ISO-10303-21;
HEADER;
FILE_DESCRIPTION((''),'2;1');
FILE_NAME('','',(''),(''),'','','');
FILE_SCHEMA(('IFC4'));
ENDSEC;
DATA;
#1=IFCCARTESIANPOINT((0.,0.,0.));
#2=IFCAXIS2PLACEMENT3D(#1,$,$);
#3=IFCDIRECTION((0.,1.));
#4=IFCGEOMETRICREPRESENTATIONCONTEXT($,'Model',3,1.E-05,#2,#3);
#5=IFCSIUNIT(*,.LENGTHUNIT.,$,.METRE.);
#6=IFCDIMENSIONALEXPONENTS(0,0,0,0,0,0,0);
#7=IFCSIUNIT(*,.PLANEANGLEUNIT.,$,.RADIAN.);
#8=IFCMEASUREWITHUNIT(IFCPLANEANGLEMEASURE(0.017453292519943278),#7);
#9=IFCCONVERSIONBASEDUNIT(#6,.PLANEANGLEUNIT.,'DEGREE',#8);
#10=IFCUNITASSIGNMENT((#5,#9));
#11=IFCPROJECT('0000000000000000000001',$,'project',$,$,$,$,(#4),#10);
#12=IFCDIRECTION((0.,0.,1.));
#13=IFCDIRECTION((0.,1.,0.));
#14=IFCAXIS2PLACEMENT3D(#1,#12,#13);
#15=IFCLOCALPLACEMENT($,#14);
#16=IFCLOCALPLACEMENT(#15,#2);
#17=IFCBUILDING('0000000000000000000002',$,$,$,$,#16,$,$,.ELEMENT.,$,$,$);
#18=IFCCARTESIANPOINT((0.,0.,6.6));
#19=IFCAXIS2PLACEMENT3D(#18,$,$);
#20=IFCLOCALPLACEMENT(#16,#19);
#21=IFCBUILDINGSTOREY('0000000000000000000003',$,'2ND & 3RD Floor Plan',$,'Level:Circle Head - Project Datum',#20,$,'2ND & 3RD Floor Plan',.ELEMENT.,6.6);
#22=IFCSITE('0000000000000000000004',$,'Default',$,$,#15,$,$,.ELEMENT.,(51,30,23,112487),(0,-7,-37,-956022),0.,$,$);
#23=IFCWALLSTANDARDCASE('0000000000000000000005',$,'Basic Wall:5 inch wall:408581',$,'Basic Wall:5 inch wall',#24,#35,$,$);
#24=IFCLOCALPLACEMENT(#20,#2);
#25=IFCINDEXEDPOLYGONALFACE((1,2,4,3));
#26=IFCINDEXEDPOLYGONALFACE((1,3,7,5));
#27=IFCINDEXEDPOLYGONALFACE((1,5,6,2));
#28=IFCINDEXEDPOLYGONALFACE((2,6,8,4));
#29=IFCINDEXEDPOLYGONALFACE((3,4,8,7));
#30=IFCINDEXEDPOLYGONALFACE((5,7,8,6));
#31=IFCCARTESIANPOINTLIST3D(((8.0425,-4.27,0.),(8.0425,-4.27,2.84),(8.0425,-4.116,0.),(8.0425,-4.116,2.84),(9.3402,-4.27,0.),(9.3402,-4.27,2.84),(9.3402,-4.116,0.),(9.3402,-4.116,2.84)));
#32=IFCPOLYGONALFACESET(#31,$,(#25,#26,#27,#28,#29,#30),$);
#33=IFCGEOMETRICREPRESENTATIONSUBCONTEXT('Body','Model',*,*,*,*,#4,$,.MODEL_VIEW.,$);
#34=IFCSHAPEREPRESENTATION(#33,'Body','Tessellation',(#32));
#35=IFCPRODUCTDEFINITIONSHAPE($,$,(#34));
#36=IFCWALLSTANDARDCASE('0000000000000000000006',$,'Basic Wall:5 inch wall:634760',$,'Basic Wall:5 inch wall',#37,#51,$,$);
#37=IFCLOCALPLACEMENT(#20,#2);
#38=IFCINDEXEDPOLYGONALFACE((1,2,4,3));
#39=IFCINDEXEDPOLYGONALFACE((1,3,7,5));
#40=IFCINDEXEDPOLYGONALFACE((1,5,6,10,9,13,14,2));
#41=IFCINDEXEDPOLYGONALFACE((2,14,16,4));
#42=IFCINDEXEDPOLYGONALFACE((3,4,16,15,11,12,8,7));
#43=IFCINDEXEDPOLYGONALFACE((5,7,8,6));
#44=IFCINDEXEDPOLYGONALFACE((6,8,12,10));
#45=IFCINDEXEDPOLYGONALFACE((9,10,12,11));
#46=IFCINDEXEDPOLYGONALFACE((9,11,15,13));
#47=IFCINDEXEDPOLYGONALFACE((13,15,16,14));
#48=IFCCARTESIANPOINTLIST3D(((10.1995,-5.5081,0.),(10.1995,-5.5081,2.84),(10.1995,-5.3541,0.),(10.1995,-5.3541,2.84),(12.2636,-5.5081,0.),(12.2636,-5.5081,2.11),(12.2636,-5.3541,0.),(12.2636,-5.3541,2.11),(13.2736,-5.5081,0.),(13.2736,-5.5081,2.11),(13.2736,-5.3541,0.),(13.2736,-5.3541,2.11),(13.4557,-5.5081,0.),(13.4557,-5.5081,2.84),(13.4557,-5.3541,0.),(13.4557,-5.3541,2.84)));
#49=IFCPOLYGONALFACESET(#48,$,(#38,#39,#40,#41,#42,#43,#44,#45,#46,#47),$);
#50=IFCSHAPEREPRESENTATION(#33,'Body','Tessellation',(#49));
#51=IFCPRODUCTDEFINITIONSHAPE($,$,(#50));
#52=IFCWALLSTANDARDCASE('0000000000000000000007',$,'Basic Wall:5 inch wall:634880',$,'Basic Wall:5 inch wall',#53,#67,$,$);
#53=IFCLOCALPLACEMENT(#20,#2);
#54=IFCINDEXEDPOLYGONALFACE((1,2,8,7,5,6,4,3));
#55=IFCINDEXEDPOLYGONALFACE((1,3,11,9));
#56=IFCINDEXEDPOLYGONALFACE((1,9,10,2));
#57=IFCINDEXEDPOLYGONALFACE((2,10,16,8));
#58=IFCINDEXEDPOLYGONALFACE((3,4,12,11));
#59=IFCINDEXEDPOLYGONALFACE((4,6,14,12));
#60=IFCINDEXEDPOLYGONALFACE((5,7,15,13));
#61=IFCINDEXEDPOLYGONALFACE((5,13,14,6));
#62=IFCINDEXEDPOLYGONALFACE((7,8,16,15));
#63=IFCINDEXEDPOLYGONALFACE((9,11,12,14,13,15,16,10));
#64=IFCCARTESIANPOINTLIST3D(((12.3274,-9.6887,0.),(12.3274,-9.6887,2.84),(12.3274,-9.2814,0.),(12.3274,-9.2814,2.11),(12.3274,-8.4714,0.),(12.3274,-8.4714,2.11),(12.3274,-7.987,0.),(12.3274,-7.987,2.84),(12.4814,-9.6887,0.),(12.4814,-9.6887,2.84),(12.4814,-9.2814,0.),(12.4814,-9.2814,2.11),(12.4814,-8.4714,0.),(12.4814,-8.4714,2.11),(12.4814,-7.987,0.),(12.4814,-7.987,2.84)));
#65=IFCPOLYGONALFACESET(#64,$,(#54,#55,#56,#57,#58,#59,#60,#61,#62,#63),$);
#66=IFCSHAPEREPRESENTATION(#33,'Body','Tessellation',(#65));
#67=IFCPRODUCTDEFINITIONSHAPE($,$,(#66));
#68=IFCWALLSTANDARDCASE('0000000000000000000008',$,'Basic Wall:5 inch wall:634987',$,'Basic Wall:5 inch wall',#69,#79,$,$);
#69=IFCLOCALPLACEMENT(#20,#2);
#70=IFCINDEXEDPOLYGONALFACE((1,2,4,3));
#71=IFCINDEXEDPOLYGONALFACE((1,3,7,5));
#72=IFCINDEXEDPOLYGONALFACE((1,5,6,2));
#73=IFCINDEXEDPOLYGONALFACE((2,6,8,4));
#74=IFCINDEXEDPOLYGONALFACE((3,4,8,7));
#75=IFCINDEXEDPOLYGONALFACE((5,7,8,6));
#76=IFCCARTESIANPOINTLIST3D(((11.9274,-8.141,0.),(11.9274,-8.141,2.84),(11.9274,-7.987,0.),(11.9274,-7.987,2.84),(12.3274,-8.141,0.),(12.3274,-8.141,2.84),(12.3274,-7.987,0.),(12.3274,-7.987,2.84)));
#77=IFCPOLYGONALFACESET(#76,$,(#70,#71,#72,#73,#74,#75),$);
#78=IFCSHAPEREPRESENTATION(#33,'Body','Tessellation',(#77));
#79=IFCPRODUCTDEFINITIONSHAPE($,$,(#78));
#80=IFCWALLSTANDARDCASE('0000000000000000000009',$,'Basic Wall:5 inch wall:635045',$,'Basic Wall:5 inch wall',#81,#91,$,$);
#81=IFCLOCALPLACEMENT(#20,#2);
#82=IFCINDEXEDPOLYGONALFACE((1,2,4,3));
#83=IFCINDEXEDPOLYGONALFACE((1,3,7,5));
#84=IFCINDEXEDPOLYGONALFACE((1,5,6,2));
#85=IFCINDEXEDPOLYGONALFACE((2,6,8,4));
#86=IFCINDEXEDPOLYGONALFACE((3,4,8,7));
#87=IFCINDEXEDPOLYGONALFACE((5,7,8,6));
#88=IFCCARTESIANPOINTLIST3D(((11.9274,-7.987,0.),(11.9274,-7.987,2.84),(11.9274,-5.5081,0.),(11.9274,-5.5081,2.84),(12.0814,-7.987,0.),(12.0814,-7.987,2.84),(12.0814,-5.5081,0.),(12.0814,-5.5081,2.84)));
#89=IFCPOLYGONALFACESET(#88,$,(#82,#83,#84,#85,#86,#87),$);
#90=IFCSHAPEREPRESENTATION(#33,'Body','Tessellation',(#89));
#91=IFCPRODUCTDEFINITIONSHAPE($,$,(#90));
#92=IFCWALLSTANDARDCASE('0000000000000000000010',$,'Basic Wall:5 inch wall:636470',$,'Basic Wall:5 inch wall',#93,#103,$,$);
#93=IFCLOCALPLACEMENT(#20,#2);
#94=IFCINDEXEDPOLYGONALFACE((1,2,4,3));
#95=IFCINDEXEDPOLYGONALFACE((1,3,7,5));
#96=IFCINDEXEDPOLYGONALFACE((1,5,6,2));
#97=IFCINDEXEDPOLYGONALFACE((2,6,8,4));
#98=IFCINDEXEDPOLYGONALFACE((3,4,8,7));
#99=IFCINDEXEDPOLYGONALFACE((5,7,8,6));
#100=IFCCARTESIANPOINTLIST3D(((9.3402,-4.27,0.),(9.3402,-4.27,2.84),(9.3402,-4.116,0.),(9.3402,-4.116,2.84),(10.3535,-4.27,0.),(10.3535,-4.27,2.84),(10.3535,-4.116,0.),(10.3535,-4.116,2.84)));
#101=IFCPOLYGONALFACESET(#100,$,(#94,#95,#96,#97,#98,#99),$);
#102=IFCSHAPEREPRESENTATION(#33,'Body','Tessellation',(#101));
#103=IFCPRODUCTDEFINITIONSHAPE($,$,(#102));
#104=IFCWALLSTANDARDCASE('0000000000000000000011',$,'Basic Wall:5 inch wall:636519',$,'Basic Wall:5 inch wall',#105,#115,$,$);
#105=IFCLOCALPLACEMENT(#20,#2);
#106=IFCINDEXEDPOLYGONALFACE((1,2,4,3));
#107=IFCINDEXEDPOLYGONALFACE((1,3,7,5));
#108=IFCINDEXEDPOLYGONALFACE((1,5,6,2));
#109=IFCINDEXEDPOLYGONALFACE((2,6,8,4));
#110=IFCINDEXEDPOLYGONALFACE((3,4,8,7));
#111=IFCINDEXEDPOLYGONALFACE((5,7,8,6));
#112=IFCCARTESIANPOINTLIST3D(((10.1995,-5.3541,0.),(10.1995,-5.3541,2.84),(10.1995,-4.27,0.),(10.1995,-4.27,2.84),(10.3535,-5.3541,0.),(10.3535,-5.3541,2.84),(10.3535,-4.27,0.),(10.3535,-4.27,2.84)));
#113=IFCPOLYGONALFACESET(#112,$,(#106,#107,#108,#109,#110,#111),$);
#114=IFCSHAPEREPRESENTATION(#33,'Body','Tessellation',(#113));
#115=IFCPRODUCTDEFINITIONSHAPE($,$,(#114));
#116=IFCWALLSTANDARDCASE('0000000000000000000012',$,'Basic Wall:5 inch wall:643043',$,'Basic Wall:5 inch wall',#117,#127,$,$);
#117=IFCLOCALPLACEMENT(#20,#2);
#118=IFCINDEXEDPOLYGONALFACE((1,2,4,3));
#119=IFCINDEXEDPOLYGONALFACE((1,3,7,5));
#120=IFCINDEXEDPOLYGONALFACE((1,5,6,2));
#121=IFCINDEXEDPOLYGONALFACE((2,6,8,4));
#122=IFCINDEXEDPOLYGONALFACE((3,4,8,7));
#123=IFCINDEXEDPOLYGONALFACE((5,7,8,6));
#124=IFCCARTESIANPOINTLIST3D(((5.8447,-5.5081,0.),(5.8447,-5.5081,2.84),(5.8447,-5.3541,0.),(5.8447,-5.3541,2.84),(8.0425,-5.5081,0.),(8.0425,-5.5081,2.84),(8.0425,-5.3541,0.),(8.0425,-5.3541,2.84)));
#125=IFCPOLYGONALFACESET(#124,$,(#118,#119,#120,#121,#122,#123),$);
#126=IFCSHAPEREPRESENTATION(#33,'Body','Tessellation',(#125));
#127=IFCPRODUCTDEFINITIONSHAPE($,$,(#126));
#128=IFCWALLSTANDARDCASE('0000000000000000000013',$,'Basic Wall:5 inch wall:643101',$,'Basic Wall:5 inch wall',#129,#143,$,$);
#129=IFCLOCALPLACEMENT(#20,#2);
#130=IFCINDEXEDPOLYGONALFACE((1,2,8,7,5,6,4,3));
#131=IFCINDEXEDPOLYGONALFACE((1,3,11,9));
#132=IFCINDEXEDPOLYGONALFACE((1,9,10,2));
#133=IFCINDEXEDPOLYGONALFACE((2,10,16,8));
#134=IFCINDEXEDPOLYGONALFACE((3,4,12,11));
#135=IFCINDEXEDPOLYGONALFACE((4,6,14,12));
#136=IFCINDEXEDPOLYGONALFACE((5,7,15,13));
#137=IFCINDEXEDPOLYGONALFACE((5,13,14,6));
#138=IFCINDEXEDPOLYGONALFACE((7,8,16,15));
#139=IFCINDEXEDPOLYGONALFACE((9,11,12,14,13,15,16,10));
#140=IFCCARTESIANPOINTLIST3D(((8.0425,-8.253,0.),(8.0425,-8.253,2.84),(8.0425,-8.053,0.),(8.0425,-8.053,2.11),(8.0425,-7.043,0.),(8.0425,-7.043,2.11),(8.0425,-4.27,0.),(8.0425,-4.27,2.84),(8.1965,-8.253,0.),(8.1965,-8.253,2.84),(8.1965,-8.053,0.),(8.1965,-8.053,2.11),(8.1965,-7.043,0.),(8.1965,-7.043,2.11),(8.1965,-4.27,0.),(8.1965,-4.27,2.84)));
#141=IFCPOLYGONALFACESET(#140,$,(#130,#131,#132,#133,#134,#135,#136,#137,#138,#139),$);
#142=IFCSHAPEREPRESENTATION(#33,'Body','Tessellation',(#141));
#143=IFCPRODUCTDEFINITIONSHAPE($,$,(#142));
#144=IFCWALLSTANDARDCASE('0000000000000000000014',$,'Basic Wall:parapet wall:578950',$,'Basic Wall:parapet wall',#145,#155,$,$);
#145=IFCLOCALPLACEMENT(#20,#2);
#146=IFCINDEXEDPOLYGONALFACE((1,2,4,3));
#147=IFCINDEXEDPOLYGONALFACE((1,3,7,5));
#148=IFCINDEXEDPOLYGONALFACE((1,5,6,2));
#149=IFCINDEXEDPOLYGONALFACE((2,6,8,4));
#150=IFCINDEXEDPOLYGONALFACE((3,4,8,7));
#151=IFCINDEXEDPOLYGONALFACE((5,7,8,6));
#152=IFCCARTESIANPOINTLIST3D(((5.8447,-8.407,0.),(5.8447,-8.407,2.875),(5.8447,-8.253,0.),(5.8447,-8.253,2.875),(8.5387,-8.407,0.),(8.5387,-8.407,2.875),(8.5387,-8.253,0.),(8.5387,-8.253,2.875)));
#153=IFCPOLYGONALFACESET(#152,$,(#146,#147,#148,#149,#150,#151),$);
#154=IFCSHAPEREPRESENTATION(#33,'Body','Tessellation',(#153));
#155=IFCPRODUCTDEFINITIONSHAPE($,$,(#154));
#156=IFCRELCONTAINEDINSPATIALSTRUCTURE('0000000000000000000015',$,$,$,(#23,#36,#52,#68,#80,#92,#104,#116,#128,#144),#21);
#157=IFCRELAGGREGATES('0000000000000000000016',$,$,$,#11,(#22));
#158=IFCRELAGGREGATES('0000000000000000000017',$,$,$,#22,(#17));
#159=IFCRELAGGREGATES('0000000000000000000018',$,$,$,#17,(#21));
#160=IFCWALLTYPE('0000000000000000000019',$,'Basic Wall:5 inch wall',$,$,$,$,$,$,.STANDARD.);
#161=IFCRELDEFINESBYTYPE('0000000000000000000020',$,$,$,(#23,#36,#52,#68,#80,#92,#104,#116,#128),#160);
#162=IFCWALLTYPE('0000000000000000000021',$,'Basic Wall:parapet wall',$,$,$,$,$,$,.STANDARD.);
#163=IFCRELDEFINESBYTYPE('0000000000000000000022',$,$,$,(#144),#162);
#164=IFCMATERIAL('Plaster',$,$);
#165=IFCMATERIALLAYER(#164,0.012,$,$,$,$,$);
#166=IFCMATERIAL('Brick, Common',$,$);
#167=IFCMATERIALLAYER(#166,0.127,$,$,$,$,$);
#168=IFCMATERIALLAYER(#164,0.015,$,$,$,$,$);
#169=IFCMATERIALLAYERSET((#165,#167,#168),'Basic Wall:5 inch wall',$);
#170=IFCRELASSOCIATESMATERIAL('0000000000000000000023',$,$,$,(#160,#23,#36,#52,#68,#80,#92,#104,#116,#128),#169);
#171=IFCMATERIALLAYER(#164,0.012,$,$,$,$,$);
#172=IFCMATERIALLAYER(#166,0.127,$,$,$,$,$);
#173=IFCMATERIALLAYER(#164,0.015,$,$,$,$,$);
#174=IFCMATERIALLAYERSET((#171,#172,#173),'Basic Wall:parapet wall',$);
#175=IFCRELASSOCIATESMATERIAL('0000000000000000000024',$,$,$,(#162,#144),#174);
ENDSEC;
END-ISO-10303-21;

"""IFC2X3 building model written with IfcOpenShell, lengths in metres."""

from ifc_helpers import new_model, entity, si_unit, converted_unit, direction, frame, frame_2d, origin, place, context, subcontext, project, spatial, polyline, rectangle, extrude, clip, bounded_halfspace, material, layer, layer_set, layer_usage, type_object, element, save


model = new_model("IFC2X3")

# Units and contexts
model_context = context("Model", 3, precision=1e-05, world=origin(), true_north=direction((0.0, 1.0)))
body_context = subcontext(model_context, "Body", "Model", "MODEL_VIEW")
ifc_project = project(units=[si_unit("LENGTHUNIT", "METRE"), converted_unit("PLANEANGLEUNIT", "DEGREE", entity("IfcPlaneAngleMeasure", 0.017453292519943278), si_unit("PLANEANGLEUNIT", "RADIAN"), dimensions=[0, 0, 0, 0, 0, 0, 0])], contexts=[model_context])

# Site, building, storey
site_placement = place(None, frame((0.0, 0.0, 0.0), z_axis=(0.0, 0.0, 1.0), x_axis=(0.0, 1.0, 0.0)))
site = spatial("IfcSite", under=ifc_project, at=site_placement, Name="Default", CompositionType="ELEMENT", RefLatitude=(51, 30, 23, 112487), RefLongitude=(0, -7, -37, -956022), RefElevation=0.0)
building_placement = place(site_placement, origin())
building = spatial("IfcBuilding", under=site, at=building_placement, CompositionType="ELEMENT")
storey_placement = place(building_placement, frame((0.0, 0.0, 6.6)))
storey = spatial("IfcBuildingStorey", under=building, at=storey_placement, Name="2ND & 3RD Floor Plan", ObjectType="Level:Circle Head - Project Datum", LongName="2ND & 3RD Floor Plan", CompositionType="ELEMENT", Elevation=6.6)

# Wall
ifc_material_1 = material(Name="Plaster")
ifc_layer_1 = layer(ifc_material_1, 0.012)
ifc_material_2 = material(Name="Brick, Common")
ifc_layer_2 = layer(ifc_material_2, 0.127)
ifc_layer_3 = layer(ifc_material_1, 0.015)
ifc_layer_set_1 = layer_set([ifc_layer_1, ifc_layer_2, ifc_layer_3], Name="Basic Wall:5 inch wall")
ifc_layer_usage_1 = layer_usage(ifc_layer_set_1, "AXIS2", "NEGATIVE", 0.077)
wall_type_1 = type_object("IfcWallType", Name="Basic Wall:5 inch wall", PredefinedType="STANDARD", material=ifc_layer_set_1)
wall_1_placement = place(storey_placement, frame((9.3402, -4.193, 0.0), z_axis=(0.0, 0.0, 1.0), x_axis=(-1.0, 0.0, 0.0)))
element("IfcWallStandardCase", 1, at=wall_1_placement, inside=storey, type_object=wall_type_1, material=ifc_layer_usage_1, Name="Basic Wall:5 inch wall:408581", ObjectType="Basic Wall:5 inch wall", context=body_context, shape_type="SweptSolid", body=[
    extrude(rectangle(XDim=1.2977, YDim=0.154, at=frame_2d((0.6489, 0.0), x_axis=(-1.0, 0.0))), origin(), (0.0, 0.0, 1.0), 2.84),
])

# Walls, openings
ifc_layer_usage_2 = layer_usage(ifc_layer_set_1, "AXIS2", "NEGATIVE", 0.077)
wall_2_placement = place(storey_placement, frame((10.1995, -5.4311, 0.0)))
wall_2 = element("IfcWallStandardCase", 2, at=wall_2_placement, inside=storey, type_object=wall_type_1, material=ifc_layer_usage_2, Name="Basic Wall:5 inch wall:634760", ObjectType="Basic Wall:5 inch wall", context=body_context, shape_type="SweptSolid", body=[
    extrude(rectangle(XDim=3.2562, YDim=0.154, at=frame_2d((1.6281, 0.0), x_axis=(-1.0, 0.0))), origin(), (0.0, 0.0, 1.0), 2.84),
])
opening_1_placement = place(wall_2_placement, frame((2.064, -0.077, 0.0)))
element("IfcOpeningElement", 3, at=opening_1_placement, cuts=wall_2, ObjectType="Opening", context=body_context, shape_type="SweptSolid", body=[
    extrude(rectangle(XDim=2.11, YDim=1.01, at=frame_2d((1.055, 0.505), x_axis=(1.0, 0.0))), frame((0.0, 0.0, 0.0), z_axis=(0.0, 1.0, 0.0), x_axis=(0.0, 0.0, 1.0)), (0.0, 0.0, 1.0), 0.154),
])
ifc_layer_usage_3 = layer_usage(ifc_layer_set_1, "AXIS2", "NEGATIVE", 0.077)
wall_3_placement = place(storey_placement, frame((12.4044, -7.987, 0.0), z_axis=(0.0, 0.0, 1.0), x_axis=(0.0, -1.0, 0.0)))
wall_3 = element("IfcWallStandardCase", 4, at=wall_3_placement, inside=storey, type_object=wall_type_1, material=ifc_layer_usage_3, Name="Basic Wall:5 inch wall:634880", ObjectType="Basic Wall:5 inch wall", context=body_context, shape_type="SweptSolid", body=[
    extrude(rectangle(XDim=1.7017, YDim=0.154, at=frame_2d((0.8508, 0.0), x_axis=(1.0, 0.0))), origin(), (0.0, 0.0, 1.0), 2.84),
])
opening_2_placement = place(wall_3_placement, frame((1.2943, 0.077, 0.0)))
element("IfcOpeningElement", 5, at=opening_2_placement, cuts=wall_3, ObjectType="Opening", context=body_context, shape_type="SweptSolid", body=[
    extrude(rectangle(XDim=2.11, YDim=0.81, at=frame_2d((1.055, 0.405), x_axis=(1.0, 0.0))), frame((0.0, 0.0, 0.0), z_axis=(0.0, -1.0, 0.0), x_axis=(0.0, 0.0, 1.0)), (0.0, 0.0, 1.0), 0.154),
])

# Walls
ifc_layer_usage_4 = layer_usage(ifc_layer_set_1, "AXIS2", "NEGATIVE", 0.077)
wall_4_placement = place(storey_placement, frame((12.3274, -8.064, 0.0), z_axis=(0.0, 0.0, 1.0), x_axis=(-1.0, 0.0, 0.0)))
element("IfcWallStandardCase", 6, at=wall_4_placement, inside=storey, type_object=wall_type_1, material=ifc_layer_usage_4, Name="Basic Wall:5 inch wall:634987", ObjectType="Basic Wall:5 inch wall", context=body_context, shape_type="SweptSolid", body=[
    extrude(rectangle(XDim=0.4, YDim=0.154, at=frame_2d((0.2, 0.0), x_axis=(-1.0, 0.0))), origin(), (0.0, 0.0, 1.0), 2.84),
])
ifc_layer_usage_5 = layer_usage(ifc_layer_set_1, "AXIS2", "NEGATIVE", 0.077)
wall_5_placement = place(storey_placement, frame((12.0044, -7.987, 0.0), z_axis=(0.0, 0.0, 1.0), x_axis=(0.0, 1.0, 0.0)))
element("IfcWallStandardCase", 7, at=wall_5_placement, inside=storey, type_object=wall_type_1, material=ifc_layer_usage_5, Name="Basic Wall:5 inch wall:635045", ObjectType="Basic Wall:5 inch wall", context=body_context, shape_type="SweptSolid", body=[
    extrude(rectangle(XDim=2.4789, YDim=0.154, at=frame_2d((1.2394, 0.0), x_axis=(-1.0, 0.0))), origin(), (0.0, 0.0, 1.0), 2.84),
])
ifc_layer_usage_6 = layer_usage(ifc_layer_set_1, "AXIS2", "NEGATIVE", 0.077)
wall_6_placement = place(storey_placement, frame((9.3402, -4.193, 0.0)))
element("IfcWallStandardCase", 8, at=wall_6_placement, inside=storey, type_object=wall_type_1, material=ifc_layer_usage_6, Name="Basic Wall:5 inch wall:636470", ObjectType="Basic Wall:5 inch wall", context=body_context, shape_type="SweptSolid", body=[
    extrude(rectangle(XDim=1.0133, YDim=0.154, at=frame_2d((0.5067, 0.0), x_axis=(-1.0, 0.0))), origin(), (0.0, 0.0, 1.0), 2.84),
])
ifc_layer_usage_7 = layer_usage(ifc_layer_set_1, "AXIS2", "NEGATIVE", 0.077)
wall_7_placement = place(storey_placement, frame((10.2765, -4.27, 0.0), z_axis=(0.0, 0.0, 1.0), x_axis=(0.0, -1.0, 0.0)))
element("IfcWallStandardCase", 9, at=wall_7_placement, inside=storey, type_object=wall_type_1, material=ifc_layer_usage_7, Name="Basic Wall:5 inch wall:636519", ObjectType="Basic Wall:5 inch wall", context=body_context, shape_type="SweptSolid", body=[
    extrude(rectangle(XDim=1.0841, YDim=0.154, at=frame_2d((0.5421, 0.0), x_axis=(-1.0, 0.0))), origin(), (0.0, 0.0, 1.0), 2.84),
])
ifc_layer_usage_8 = layer_usage(ifc_layer_set_1, "AXIS2", "NEGATIVE", 0.077)
wall_8_placement = place(storey_placement, frame((5.8447, -5.4311, 0.0)))
element("IfcWallStandardCase", 10, at=wall_8_placement, inside=storey, type_object=wall_type_1, material=ifc_layer_usage_8, Name="Basic Wall:5 inch wall:643043", ObjectType="Basic Wall:5 inch wall", context=body_context, shape_type="SweptSolid", body=[
    extrude(rectangle(XDim=2.1978, YDim=0.154, at=frame_2d((1.0989, 0.0), x_axis=(-1.0, 0.0))), origin(), (0.0, 0.0, 1.0), 2.84),
])

# Wall, opening
ifc_layer_usage_9 = layer_usage(ifc_layer_set_1, "AXIS2", "NEGATIVE", 0.077)
wall_9_placement = place(storey_placement, frame((8.1195, -4.27, 0.0), z_axis=(0.0, 0.0, 1.0), x_axis=(0.0, -1.0, 0.0)))
wall_9 = element("IfcWallStandardCase", 11, at=wall_9_placement, inside=storey, type_object=wall_type_1, material=ifc_layer_usage_9, Name="Basic Wall:5 inch wall:643101", ObjectType="Basic Wall:5 inch wall", context=body_context, shape_type="SweptSolid", body=[
    extrude(rectangle(XDim=3.983, YDim=0.154, at=frame_2d((1.9915, 0.0), x_axis=(1.0, 0.0))), origin(), (0.0, 0.0, 1.0), 2.84),
])
opening_3_placement = place(wall_9_placement, frame((2.773, -0.077, 0.0)))
element("IfcOpeningElement", 12, at=opening_3_placement, cuts=wall_9, ObjectType="Opening", context=body_context, shape_type="SweptSolid", body=[
    extrude(rectangle(XDim=2.11, YDim=1.01, at=frame_2d((1.055, 0.505), x_axis=(1.0, 0.0))), frame((0.0, 0.0, 0.0), z_axis=(0.0, 1.0, 0.0), x_axis=(0.0, 0.0, 1.0)), (0.0, 0.0, 1.0), 0.154),
])

# Wall
ifc_layer_4 = layer(ifc_material_1, 0.012)
ifc_layer_5 = layer(ifc_material_2, 0.127)
ifc_layer_6 = layer(ifc_material_1, 0.015)
ifc_layer_set_2 = layer_set([ifc_layer_4, ifc_layer_5, ifc_layer_6], Name="Basic Wall:parapet wall")
ifc_layer_usage_10 = layer_usage(ifc_layer_set_2, "AXIS2", "NEGATIVE", 0.077)
wall_type_2 = type_object("IfcWallType", Name="Basic Wall:parapet wall", PredefinedType="STANDARD", material=ifc_layer_set_2)
wall_10_placement = place(storey_placement, frame((5.8447, -8.33, 0.0)))
element("IfcWallStandardCase", 13, at=wall_10_placement, inside=storey, type_object=wall_type_2, material=ifc_layer_usage_10, Name="Basic Wall:parapet wall:578950", ObjectType="Basic Wall:parapet wall", context=body_context, shape_type="Clipping", body=[
    clip(extrude(rectangle(XDim=2.694, YDim=0.154, at=frame_2d((1.347, 0.0), x_axis=(-1.0, 0.0))), origin(), (0.0, 0.0, 1.0), 2.875), bounded_halfspace(frame((0.0, -0.077, 2.875), z_axis=(0.0, 0.0, -1.0), x_axis=(0.0, -1.0, 0.0)), True, frame((0.0, -0.077, 2.875)), polyline([(0.0, 0.0), (2.54, 0.0), (2.694, 0.0), (2.694, 0.154), (0.0, 0.154), (0.0, 0.0)]))),
])

save(model, "model.ifc")
